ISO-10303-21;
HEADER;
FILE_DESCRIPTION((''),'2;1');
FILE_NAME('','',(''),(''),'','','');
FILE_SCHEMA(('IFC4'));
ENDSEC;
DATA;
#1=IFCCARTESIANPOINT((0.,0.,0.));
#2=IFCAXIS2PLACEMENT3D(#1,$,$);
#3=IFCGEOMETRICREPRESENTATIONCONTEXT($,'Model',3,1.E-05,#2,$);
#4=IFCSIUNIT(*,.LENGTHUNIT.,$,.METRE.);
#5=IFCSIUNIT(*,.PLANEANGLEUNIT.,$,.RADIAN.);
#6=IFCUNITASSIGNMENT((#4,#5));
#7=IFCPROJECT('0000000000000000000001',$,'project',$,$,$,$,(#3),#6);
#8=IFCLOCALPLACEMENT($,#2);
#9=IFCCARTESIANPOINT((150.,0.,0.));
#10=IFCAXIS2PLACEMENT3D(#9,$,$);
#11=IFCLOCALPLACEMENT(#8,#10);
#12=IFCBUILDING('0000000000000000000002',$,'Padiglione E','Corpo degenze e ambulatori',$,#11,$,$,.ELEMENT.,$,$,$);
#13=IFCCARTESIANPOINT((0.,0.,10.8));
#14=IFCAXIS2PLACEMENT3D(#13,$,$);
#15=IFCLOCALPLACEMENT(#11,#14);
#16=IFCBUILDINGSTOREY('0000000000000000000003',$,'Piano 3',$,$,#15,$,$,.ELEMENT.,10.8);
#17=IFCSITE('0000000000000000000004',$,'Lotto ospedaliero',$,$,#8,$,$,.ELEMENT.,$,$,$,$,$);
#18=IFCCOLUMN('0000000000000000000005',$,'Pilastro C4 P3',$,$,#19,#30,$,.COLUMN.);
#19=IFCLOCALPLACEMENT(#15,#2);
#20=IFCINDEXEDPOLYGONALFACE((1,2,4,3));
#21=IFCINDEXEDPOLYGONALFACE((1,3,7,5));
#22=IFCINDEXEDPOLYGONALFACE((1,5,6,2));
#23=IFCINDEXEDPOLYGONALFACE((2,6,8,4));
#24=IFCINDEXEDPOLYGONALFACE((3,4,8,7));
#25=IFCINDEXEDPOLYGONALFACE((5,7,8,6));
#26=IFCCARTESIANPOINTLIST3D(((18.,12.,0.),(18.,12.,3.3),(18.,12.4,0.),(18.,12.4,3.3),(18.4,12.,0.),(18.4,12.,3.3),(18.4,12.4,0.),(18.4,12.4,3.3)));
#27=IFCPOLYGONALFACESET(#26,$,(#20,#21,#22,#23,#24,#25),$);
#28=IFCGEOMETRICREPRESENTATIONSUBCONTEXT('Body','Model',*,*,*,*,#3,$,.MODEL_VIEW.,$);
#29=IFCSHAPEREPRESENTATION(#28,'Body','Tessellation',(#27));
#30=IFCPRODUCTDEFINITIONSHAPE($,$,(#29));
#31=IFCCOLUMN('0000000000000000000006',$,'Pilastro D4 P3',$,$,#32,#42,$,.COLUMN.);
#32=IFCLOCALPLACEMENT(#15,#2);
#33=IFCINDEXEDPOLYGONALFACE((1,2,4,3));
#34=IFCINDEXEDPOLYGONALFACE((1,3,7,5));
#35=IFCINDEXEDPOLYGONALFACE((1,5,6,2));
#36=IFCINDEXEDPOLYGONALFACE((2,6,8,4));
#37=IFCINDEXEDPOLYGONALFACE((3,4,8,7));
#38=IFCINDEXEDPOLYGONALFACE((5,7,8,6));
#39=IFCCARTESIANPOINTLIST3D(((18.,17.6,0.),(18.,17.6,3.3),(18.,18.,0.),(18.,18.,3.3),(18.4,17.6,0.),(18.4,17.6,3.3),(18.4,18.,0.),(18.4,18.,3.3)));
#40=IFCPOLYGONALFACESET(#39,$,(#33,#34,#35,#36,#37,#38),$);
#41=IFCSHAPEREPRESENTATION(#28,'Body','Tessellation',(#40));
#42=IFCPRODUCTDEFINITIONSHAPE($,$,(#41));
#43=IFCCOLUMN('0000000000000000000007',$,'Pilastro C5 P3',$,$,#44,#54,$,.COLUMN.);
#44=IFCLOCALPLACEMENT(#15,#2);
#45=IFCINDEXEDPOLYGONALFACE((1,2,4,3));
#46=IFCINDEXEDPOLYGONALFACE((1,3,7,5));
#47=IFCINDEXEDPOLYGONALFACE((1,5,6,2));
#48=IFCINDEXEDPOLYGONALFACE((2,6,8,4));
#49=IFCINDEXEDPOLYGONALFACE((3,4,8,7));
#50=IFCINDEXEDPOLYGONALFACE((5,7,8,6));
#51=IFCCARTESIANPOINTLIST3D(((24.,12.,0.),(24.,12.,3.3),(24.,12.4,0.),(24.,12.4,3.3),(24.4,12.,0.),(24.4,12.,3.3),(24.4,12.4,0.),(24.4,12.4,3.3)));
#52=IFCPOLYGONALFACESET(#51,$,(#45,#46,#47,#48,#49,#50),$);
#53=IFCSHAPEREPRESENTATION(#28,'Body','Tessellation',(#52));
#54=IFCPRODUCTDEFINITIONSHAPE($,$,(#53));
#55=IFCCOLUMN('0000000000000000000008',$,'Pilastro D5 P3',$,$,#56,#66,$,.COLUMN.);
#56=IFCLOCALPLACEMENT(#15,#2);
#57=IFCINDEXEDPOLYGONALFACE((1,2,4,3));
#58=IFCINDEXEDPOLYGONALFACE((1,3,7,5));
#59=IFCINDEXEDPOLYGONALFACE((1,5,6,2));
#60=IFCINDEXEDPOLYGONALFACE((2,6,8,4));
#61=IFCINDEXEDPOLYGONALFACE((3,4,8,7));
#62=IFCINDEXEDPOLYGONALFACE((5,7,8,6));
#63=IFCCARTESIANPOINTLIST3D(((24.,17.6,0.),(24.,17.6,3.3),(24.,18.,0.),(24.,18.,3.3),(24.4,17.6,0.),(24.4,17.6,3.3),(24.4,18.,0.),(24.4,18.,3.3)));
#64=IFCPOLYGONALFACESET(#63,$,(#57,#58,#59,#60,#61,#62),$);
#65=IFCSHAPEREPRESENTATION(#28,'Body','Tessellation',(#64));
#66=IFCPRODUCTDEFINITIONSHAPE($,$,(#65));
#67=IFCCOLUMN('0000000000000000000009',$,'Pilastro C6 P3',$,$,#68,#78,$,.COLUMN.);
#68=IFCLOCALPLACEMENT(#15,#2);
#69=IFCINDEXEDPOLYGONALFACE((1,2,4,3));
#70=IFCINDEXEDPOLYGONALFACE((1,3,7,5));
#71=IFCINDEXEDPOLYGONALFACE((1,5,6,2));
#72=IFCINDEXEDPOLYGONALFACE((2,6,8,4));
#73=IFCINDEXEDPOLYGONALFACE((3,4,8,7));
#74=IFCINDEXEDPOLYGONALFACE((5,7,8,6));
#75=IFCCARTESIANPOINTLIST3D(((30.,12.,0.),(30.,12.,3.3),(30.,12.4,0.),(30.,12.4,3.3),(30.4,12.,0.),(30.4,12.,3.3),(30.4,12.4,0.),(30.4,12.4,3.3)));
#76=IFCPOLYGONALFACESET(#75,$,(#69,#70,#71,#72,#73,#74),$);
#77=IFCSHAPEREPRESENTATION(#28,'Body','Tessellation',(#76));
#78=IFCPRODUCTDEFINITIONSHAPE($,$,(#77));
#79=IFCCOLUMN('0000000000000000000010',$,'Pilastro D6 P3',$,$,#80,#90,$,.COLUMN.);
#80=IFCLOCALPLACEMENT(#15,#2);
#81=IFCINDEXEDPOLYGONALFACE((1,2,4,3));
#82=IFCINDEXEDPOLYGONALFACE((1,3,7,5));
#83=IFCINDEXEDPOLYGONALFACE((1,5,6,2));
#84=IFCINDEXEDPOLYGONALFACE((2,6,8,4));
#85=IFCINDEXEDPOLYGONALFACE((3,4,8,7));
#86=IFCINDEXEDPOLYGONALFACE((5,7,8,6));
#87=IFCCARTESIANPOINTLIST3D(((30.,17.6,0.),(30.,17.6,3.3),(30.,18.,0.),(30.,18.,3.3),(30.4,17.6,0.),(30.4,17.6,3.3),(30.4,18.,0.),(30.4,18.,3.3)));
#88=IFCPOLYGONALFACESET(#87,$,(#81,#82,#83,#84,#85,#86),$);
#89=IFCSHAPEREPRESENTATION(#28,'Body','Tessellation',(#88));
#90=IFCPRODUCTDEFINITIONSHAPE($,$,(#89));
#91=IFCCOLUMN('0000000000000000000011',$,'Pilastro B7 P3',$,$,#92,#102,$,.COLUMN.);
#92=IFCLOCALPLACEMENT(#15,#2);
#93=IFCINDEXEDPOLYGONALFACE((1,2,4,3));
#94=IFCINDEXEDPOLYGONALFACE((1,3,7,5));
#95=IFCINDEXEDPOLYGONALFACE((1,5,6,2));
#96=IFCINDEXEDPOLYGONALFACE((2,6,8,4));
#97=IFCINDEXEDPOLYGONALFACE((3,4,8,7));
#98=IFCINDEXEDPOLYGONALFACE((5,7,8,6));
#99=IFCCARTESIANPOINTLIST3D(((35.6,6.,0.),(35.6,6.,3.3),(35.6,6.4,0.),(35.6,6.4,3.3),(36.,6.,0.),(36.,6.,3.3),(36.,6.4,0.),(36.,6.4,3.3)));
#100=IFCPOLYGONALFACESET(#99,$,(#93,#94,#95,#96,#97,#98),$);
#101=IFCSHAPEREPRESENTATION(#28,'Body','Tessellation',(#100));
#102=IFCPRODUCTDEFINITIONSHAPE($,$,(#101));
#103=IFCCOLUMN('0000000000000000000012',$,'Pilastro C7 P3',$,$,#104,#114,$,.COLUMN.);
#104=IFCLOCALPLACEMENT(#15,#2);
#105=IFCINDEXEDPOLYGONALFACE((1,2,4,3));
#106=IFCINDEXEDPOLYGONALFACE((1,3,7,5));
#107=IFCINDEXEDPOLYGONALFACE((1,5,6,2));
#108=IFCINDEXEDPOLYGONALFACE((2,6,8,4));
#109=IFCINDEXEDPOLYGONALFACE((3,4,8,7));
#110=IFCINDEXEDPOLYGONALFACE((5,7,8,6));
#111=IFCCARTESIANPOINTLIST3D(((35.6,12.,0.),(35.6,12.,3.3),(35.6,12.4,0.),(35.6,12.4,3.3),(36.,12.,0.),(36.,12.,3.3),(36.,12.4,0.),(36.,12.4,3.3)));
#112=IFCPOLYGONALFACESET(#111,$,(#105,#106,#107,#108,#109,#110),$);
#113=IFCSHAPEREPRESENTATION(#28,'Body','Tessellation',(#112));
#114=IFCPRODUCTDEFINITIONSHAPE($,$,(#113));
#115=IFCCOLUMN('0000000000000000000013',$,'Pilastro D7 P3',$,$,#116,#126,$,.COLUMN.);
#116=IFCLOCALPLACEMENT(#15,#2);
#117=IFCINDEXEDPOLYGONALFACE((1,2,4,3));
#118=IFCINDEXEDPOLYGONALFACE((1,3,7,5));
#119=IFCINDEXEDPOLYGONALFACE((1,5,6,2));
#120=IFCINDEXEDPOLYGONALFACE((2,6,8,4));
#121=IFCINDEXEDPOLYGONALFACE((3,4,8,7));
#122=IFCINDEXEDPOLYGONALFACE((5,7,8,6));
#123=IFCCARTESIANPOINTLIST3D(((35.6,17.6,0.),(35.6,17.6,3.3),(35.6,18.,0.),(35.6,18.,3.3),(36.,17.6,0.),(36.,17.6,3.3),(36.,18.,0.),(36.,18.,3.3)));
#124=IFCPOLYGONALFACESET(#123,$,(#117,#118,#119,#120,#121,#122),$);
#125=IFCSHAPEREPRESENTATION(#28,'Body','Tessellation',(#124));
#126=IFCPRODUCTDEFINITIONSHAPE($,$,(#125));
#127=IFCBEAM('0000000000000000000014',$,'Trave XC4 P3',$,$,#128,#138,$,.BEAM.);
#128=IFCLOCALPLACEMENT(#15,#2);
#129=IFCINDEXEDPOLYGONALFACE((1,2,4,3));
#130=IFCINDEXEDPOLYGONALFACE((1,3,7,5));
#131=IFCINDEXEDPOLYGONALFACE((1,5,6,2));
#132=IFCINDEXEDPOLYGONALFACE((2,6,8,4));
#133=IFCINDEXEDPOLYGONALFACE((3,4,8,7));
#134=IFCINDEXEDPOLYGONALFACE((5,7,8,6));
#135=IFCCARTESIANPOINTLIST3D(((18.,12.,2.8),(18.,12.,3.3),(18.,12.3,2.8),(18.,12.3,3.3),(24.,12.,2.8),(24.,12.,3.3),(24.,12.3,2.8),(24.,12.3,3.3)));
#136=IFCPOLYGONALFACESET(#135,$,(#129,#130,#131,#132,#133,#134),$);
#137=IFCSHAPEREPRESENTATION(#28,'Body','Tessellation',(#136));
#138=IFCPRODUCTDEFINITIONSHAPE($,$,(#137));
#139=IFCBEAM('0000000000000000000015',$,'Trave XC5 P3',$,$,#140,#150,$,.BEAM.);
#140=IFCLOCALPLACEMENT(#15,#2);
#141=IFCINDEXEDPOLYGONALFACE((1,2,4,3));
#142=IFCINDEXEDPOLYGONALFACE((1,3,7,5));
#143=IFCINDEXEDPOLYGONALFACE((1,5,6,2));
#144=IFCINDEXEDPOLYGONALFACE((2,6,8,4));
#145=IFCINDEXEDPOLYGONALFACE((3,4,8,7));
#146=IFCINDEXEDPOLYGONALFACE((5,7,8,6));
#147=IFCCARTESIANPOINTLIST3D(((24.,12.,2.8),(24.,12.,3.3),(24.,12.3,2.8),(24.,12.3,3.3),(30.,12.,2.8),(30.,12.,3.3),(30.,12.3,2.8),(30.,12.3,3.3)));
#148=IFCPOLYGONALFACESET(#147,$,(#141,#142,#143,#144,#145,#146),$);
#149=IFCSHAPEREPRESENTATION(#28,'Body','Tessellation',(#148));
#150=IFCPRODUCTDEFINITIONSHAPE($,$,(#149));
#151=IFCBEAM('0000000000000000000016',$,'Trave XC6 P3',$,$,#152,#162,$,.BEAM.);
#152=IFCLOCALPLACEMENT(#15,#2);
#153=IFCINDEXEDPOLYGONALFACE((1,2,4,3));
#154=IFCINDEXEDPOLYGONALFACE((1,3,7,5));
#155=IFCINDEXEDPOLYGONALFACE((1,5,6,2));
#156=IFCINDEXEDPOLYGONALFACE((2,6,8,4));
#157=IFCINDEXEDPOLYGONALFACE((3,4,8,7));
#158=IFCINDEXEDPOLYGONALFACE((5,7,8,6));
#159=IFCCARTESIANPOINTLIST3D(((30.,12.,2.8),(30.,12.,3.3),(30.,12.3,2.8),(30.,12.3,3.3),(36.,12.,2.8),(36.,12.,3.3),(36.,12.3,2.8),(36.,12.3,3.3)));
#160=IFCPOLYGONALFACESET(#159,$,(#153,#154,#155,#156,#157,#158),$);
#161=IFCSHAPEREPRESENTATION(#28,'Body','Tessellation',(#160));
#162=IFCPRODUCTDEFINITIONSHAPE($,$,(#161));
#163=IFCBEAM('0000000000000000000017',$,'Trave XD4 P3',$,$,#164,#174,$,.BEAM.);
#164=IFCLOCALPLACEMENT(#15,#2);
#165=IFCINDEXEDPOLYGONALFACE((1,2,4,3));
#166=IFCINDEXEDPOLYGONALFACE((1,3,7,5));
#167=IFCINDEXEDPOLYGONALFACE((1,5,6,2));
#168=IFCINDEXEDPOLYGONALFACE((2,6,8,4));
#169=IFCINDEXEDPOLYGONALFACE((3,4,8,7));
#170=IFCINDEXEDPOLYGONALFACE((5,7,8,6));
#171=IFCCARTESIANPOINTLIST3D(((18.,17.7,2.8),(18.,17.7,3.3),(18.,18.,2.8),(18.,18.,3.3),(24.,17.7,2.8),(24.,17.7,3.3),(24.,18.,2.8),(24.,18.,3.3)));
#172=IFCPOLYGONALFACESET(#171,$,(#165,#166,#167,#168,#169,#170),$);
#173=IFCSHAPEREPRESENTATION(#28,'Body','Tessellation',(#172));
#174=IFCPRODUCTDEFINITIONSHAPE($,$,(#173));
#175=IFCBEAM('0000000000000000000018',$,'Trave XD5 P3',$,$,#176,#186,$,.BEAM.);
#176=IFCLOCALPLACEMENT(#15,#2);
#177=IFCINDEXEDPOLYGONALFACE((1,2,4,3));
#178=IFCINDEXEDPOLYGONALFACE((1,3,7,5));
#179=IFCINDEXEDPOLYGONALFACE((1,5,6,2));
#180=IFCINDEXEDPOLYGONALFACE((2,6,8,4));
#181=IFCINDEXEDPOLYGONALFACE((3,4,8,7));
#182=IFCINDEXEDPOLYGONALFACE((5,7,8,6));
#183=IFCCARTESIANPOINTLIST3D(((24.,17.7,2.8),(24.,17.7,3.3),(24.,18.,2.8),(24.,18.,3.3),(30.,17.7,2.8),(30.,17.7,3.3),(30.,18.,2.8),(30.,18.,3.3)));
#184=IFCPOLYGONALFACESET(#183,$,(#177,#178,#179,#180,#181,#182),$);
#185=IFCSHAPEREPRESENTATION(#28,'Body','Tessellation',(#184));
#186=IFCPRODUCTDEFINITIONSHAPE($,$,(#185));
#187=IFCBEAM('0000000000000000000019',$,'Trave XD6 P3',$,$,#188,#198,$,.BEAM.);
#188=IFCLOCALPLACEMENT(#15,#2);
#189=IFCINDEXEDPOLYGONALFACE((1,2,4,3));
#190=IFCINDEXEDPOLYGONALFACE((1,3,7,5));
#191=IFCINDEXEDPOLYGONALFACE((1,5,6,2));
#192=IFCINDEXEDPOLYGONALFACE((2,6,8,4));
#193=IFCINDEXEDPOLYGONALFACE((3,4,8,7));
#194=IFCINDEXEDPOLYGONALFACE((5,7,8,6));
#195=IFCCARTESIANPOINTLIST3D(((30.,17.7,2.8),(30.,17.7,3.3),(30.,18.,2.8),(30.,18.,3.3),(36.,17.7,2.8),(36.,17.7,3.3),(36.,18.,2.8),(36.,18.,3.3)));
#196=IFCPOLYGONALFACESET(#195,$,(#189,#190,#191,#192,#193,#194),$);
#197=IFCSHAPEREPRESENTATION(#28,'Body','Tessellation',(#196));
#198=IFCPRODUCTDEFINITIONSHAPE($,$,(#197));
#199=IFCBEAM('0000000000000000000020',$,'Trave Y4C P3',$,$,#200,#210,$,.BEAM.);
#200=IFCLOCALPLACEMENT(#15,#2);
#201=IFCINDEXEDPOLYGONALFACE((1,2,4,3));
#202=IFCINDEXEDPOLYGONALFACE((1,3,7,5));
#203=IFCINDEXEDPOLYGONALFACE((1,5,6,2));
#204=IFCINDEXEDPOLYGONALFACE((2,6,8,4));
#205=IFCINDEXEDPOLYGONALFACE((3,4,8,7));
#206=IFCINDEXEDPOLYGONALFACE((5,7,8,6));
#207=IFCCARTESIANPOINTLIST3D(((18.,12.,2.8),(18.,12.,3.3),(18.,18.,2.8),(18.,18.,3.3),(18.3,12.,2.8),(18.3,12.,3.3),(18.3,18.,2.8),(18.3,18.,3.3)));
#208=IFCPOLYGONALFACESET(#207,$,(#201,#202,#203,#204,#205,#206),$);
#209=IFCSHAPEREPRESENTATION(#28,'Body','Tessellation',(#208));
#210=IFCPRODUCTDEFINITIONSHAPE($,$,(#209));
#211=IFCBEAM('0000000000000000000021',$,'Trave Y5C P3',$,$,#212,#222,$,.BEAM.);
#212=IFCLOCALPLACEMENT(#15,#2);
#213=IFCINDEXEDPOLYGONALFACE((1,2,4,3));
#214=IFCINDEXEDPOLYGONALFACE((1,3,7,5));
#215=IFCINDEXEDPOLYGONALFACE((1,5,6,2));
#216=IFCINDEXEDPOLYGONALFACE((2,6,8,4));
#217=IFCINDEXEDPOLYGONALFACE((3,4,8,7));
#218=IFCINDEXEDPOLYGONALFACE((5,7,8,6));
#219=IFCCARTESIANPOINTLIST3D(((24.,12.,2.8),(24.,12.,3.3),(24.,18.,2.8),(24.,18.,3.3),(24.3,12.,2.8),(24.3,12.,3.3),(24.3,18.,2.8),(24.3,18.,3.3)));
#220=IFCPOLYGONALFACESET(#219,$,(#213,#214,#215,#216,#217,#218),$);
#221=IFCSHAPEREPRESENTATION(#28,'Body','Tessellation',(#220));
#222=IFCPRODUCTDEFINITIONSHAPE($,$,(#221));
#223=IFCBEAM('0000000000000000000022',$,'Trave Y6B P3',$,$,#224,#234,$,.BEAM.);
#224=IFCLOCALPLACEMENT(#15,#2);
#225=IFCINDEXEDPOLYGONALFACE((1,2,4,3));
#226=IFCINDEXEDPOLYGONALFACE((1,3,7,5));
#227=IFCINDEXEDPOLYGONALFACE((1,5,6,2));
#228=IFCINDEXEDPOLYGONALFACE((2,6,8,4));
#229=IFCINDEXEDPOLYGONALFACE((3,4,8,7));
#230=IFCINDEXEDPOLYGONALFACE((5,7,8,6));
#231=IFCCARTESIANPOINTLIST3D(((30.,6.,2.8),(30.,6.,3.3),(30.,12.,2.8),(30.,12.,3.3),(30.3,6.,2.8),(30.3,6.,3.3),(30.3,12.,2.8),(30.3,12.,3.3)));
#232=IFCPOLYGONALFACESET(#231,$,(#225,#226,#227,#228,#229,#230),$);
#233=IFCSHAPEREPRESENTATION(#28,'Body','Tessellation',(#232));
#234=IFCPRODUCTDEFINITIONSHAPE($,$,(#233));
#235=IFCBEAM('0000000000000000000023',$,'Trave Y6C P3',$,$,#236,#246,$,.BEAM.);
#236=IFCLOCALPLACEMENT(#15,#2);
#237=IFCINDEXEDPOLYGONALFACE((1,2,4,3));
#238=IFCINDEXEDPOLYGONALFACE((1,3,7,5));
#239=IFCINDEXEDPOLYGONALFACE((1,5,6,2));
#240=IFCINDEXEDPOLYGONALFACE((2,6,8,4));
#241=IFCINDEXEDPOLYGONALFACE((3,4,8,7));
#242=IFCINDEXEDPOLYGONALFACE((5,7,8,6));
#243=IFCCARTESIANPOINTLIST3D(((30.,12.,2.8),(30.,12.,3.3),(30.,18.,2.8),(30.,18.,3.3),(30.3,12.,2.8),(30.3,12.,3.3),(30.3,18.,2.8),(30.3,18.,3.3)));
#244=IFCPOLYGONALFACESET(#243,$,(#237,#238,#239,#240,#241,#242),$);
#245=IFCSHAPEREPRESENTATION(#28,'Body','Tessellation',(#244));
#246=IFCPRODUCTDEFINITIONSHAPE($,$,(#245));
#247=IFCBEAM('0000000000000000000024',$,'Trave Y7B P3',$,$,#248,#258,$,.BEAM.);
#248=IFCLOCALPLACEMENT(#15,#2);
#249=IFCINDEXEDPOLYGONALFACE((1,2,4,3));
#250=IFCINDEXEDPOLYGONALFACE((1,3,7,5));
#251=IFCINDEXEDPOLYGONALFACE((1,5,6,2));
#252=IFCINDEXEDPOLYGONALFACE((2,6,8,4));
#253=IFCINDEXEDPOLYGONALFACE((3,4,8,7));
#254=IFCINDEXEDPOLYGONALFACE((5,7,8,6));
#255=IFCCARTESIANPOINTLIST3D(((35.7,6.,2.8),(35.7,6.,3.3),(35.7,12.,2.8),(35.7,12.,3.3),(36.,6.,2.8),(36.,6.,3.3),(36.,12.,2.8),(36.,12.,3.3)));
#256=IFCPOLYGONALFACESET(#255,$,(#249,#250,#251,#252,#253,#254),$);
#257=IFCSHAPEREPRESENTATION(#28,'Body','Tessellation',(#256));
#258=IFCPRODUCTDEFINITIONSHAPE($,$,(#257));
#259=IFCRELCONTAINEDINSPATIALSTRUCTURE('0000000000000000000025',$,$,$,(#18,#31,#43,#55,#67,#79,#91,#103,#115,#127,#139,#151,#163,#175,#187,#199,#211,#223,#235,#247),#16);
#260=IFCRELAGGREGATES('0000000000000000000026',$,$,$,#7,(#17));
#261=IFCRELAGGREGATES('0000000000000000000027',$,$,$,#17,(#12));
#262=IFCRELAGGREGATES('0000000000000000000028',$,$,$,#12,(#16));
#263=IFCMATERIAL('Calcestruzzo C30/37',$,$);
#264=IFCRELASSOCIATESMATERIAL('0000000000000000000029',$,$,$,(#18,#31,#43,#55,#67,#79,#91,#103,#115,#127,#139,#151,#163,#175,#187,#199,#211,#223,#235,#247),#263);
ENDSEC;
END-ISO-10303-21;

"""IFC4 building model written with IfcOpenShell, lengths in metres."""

from ifc_helpers import new_model, si_unit, frame, frame_2d, origin, place, context, subcontext, project, spatial, rectangle, extrude, material, element, save


model = new_model("IFC4")

# Units and contexts
model_context = context("Model", 3, precision=1e-05, world=origin())
body_context = subcontext(model_context, "Body", "Model", "MODEL_VIEW")
ifc_project = project(units=[si_unit("LENGTHUNIT", "METRE"), si_unit("PLANEANGLEUNIT", "RADIAN")], contexts=[model_context])

# Site, building, storey
site_placement = place(None, origin())
site = spatial("IfcSite", under=ifc_project, at=site_placement, Name="Lotto ospedaliero", CompositionType="ELEMENT")
building_placement = place(site_placement, frame((150.0, 0.0, 0.0)))
building = spatial("IfcBuilding", under=site, at=building_placement, Name="Padiglione E", Description="Corpo degenze e ambulatori", CompositionType="ELEMENT")
storey_placement = place(building_placement, frame((0.0, 0.0, 10.8)))
storey = spatial("IfcBuildingStorey", under=building, at=storey_placement, Name="Piano 3", CompositionType="ELEMENT", Elevation=10.8)

# Columns
ifc_material_1 = material(Name="Calcestruzzo C30/37")
for number, where, name in (
    (1, (18.0, 12.0, 0.0), "Pilastro C4 P3"),
    (2, (18.0, 17.6, 0.0), "Pilastro D4 P3"),
    (3, (24.0, 12.0, 0.0), "Pilastro C5 P3"),
    (4, (24.0, 17.6, 0.0), "Pilastro D5 P3"),
    (5, (30.0, 12.0, 0.0), "Pilastro C6 P3"),
    (6, (30.0, 17.6, 0.0), "Pilastro D6 P3"),
    (7, (35.6, 6.0, 0.0), "Pilastro B7 P3"),
    (8, (35.6, 12.0, 0.0), "Pilastro C7 P3"),
    (9, (35.6, 17.6, 0.0), "Pilastro D7 P3"),
):
    element("IfcColumn", number, at=place(storey_placement, frame(where)), inside=storey, material=ifc_material_1, Name=name, PredefinedType="COLUMN", context=body_context, shape_type="SweptSolid", body=[
        extrude(rectangle(XDim=0.4, YDim=0.4, at=frame_2d((0.2, 0.2))), origin(), (0.0, 0.0, 1.0), 3.3),
    ])

# Beams
for number, where, name in (
    (10, (18.0, 12.0, 2.8), "Trave XC4 P3"),
    (11, (24.0, 12.0, 2.8), "Trave XC5 P3"),
    (12, (30.0, 12.0, 2.8), "Trave XC6 P3"),
    (13, (18.0, 17.7, 2.8), "Trave XD4 P3"),
    (14, (24.0, 17.7, 2.8), "Trave XD5 P3"),
    (15, (30.0, 17.7, 2.8), "Trave XD6 P3"),
):
    element("IfcBeam", number, at=place(storey_placement, frame(where)), inside=storey, material=ifc_material_1, Name=name, PredefinedType="BEAM", context=body_context, shape_type="SweptSolid", body=[
        extrude(rectangle(XDim=6.0, YDim=0.3, at=frame_2d((3.0, 0.15))), origin(), (0.0, 0.0, 1.0), 0.5),
    ])
for number, where, name in (
    (16, (18.0, 12.0, 2.8), "Trave Y4C P3"),
    (17, (24.0, 12.0, 2.8), "Trave Y5C P3"),
    (18, (30.0, 6.0, 2.8), "Trave Y6B P3"),
    (19, (30.0, 12.0, 2.8), "Trave Y6C P3"),
    (20, (35.7, 6.0, 2.8), "Trave Y7B P3"),
):
    element("IfcBeam", number, at=place(storey_placement, frame(where)), inside=storey, material=ifc_material_1, Name=name, PredefinedType="BEAM", context=body_context, shape_type="SweptSolid", body=[
        extrude(rectangle(XDim=0.3, YDim=6.0, at=frame_2d((0.15, 3.0))), origin(), (0.0, 0.0, 1.0), 0.5),
    ])

save(model, "model.ifc")
